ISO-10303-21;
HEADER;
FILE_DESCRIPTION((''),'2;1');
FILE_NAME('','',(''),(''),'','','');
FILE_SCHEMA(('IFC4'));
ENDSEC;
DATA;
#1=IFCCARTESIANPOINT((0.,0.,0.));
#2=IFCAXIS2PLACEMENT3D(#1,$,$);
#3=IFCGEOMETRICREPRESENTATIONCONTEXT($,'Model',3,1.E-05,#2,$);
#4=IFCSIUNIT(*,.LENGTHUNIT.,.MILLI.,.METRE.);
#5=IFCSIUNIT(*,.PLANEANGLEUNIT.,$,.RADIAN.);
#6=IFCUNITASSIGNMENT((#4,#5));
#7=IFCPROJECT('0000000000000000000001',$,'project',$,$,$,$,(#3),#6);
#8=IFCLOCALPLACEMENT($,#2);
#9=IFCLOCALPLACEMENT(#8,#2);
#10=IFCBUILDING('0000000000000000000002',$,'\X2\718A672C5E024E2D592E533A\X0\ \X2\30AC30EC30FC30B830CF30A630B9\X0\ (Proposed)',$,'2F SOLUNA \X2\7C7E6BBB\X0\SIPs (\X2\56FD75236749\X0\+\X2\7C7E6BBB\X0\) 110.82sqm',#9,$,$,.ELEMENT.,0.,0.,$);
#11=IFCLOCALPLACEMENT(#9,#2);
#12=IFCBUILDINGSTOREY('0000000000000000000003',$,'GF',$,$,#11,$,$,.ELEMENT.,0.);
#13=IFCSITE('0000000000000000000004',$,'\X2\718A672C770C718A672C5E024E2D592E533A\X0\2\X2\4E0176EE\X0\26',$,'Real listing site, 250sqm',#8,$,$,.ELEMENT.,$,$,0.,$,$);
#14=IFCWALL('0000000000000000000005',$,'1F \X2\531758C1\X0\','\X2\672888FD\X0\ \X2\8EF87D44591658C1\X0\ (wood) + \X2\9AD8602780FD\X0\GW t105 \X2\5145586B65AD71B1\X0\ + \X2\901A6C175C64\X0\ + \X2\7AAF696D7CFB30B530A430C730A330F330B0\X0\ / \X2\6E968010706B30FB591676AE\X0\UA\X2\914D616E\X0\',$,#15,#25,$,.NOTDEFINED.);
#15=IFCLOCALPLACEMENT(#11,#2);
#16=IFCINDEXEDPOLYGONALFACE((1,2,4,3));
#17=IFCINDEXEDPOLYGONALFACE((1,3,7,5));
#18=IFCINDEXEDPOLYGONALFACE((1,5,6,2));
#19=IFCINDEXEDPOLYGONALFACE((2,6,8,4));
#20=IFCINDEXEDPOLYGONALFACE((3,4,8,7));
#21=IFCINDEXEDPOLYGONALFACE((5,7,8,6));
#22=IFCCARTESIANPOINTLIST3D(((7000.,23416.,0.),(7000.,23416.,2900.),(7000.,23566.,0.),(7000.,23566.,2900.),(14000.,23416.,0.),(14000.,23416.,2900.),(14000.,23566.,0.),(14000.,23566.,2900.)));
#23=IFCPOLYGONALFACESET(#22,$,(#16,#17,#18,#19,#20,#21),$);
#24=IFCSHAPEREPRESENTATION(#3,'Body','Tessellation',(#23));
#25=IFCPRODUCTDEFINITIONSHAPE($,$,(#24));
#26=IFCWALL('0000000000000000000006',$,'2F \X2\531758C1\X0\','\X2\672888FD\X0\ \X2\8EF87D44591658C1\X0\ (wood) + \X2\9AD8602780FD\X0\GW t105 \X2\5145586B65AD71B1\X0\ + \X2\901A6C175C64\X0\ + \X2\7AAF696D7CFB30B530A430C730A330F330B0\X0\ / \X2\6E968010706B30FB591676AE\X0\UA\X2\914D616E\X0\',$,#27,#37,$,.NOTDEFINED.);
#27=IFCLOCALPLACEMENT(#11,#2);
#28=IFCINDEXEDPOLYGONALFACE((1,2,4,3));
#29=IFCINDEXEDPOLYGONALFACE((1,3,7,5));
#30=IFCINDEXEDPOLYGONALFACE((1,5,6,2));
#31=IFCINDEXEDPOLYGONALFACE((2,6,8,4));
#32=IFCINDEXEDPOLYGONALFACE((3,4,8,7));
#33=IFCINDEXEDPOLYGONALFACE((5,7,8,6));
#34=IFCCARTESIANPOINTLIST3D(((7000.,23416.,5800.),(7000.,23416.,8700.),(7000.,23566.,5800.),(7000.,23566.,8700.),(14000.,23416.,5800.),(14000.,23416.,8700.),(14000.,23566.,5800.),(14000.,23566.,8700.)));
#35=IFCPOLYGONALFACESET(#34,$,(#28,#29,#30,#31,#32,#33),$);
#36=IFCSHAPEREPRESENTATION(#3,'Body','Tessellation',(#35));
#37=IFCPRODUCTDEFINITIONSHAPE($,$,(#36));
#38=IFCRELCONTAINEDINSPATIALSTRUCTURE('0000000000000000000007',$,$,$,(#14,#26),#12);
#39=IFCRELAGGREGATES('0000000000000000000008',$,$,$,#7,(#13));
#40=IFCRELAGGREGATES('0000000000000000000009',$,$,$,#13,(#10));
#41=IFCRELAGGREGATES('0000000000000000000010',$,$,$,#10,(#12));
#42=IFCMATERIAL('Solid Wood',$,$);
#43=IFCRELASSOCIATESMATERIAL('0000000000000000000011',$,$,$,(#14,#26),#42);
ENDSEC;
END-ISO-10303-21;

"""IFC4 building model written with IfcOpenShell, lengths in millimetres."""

from ifc_helpers import new_model, si_unit, frame, frame_2d, origin, place, context, project, spatial, rectangle, extrude, material, element, save


model = new_model("IFC4")

# Units and contexts
model_context = context("Model", 3, precision=1e-05, world=origin())
ifc_project = project(units=[si_unit("LENGTHUNIT", "METRE", prefix="MILLI"), si_unit("PLANEANGLEUNIT", "RADIAN")], contexts=[model_context])

# Site, building, storey
site_placement = place(None, origin())
site = spatial("IfcSite", under=ifc_project, at=site_placement, Name="熊本県熊本市中央区2丁目26", ObjectType="Real listing site, 250sqm", CompositionType="ELEMENT", RefElevation=0.0)
building_placement = place(site_placement, origin())
building = spatial("IfcBuilding", under=site, at=building_placement, Name="熊本市中央区 ガレージハウス (Proposed)", ObjectType="2F SOLUNA 籾殻SIPs (国産杉+籾殻) 110.82sqm", CompositionType="ELEMENT", ElevationOfRefHeight=0.0, ElevationOfTerrain=0.0)
storey_placement = place(building_placement, origin())
storey = spatial("IfcBuildingStorey", under=building, at=storey_placement, Name="GF", CompositionType="ELEMENT", Elevation=0.0)

# Shared definitions
ifc_material_1 = material(Name="Solid Wood")

# Wall
wall_1_placement = place(storey_placement, frame((3500.0, 11708.0, 0.0)))
element("IfcWall", 1, at=wall_1_placement, inside=storey, material=ifc_material_1, Name="1F 北壁", Description="木製 軸組外壁 (wood) + 高性能GW t105 充填断熱 + 通気層 + 窯業系サイディング / 準耐火・外皮UA配慮", PredefinedType="NOTDEFINED", context=model_context, shape_type="SweptSolid", body=[
    extrude(rectangle(XDim=7000.0, YDim=150.0, at=frame_2d((3500.0, 75.0))), frame((3500.0, 11708.0, 0.0)), (0.0, 0.0, 1.0), 2900.0),
])

# Wall
wall_2_placement = place(storey_placement, frame((3500.0, 11708.0, 2900.0)))
element("IfcWall", 2, at=wall_2_placement, inside=storey, material=ifc_material_1, Name="2F 北壁", Description="木製 軸組外壁 (wood) + 高性能GW t105 充填断熱 + 通気層 + 窯業系サイディング / 準耐火・外皮UA配慮", PredefinedType="NOTDEFINED", context=model_context, shape_type="SweptSolid", body=[
    extrude(rectangle(XDim=7000.0, YDim=150.0, at=frame_2d((3500.0, 75.0))), frame((3500.0, 11708.0, 2900.0)), (0.0, 0.0, 1.0), 2900.0),
])

save(model, "model.ifc")
